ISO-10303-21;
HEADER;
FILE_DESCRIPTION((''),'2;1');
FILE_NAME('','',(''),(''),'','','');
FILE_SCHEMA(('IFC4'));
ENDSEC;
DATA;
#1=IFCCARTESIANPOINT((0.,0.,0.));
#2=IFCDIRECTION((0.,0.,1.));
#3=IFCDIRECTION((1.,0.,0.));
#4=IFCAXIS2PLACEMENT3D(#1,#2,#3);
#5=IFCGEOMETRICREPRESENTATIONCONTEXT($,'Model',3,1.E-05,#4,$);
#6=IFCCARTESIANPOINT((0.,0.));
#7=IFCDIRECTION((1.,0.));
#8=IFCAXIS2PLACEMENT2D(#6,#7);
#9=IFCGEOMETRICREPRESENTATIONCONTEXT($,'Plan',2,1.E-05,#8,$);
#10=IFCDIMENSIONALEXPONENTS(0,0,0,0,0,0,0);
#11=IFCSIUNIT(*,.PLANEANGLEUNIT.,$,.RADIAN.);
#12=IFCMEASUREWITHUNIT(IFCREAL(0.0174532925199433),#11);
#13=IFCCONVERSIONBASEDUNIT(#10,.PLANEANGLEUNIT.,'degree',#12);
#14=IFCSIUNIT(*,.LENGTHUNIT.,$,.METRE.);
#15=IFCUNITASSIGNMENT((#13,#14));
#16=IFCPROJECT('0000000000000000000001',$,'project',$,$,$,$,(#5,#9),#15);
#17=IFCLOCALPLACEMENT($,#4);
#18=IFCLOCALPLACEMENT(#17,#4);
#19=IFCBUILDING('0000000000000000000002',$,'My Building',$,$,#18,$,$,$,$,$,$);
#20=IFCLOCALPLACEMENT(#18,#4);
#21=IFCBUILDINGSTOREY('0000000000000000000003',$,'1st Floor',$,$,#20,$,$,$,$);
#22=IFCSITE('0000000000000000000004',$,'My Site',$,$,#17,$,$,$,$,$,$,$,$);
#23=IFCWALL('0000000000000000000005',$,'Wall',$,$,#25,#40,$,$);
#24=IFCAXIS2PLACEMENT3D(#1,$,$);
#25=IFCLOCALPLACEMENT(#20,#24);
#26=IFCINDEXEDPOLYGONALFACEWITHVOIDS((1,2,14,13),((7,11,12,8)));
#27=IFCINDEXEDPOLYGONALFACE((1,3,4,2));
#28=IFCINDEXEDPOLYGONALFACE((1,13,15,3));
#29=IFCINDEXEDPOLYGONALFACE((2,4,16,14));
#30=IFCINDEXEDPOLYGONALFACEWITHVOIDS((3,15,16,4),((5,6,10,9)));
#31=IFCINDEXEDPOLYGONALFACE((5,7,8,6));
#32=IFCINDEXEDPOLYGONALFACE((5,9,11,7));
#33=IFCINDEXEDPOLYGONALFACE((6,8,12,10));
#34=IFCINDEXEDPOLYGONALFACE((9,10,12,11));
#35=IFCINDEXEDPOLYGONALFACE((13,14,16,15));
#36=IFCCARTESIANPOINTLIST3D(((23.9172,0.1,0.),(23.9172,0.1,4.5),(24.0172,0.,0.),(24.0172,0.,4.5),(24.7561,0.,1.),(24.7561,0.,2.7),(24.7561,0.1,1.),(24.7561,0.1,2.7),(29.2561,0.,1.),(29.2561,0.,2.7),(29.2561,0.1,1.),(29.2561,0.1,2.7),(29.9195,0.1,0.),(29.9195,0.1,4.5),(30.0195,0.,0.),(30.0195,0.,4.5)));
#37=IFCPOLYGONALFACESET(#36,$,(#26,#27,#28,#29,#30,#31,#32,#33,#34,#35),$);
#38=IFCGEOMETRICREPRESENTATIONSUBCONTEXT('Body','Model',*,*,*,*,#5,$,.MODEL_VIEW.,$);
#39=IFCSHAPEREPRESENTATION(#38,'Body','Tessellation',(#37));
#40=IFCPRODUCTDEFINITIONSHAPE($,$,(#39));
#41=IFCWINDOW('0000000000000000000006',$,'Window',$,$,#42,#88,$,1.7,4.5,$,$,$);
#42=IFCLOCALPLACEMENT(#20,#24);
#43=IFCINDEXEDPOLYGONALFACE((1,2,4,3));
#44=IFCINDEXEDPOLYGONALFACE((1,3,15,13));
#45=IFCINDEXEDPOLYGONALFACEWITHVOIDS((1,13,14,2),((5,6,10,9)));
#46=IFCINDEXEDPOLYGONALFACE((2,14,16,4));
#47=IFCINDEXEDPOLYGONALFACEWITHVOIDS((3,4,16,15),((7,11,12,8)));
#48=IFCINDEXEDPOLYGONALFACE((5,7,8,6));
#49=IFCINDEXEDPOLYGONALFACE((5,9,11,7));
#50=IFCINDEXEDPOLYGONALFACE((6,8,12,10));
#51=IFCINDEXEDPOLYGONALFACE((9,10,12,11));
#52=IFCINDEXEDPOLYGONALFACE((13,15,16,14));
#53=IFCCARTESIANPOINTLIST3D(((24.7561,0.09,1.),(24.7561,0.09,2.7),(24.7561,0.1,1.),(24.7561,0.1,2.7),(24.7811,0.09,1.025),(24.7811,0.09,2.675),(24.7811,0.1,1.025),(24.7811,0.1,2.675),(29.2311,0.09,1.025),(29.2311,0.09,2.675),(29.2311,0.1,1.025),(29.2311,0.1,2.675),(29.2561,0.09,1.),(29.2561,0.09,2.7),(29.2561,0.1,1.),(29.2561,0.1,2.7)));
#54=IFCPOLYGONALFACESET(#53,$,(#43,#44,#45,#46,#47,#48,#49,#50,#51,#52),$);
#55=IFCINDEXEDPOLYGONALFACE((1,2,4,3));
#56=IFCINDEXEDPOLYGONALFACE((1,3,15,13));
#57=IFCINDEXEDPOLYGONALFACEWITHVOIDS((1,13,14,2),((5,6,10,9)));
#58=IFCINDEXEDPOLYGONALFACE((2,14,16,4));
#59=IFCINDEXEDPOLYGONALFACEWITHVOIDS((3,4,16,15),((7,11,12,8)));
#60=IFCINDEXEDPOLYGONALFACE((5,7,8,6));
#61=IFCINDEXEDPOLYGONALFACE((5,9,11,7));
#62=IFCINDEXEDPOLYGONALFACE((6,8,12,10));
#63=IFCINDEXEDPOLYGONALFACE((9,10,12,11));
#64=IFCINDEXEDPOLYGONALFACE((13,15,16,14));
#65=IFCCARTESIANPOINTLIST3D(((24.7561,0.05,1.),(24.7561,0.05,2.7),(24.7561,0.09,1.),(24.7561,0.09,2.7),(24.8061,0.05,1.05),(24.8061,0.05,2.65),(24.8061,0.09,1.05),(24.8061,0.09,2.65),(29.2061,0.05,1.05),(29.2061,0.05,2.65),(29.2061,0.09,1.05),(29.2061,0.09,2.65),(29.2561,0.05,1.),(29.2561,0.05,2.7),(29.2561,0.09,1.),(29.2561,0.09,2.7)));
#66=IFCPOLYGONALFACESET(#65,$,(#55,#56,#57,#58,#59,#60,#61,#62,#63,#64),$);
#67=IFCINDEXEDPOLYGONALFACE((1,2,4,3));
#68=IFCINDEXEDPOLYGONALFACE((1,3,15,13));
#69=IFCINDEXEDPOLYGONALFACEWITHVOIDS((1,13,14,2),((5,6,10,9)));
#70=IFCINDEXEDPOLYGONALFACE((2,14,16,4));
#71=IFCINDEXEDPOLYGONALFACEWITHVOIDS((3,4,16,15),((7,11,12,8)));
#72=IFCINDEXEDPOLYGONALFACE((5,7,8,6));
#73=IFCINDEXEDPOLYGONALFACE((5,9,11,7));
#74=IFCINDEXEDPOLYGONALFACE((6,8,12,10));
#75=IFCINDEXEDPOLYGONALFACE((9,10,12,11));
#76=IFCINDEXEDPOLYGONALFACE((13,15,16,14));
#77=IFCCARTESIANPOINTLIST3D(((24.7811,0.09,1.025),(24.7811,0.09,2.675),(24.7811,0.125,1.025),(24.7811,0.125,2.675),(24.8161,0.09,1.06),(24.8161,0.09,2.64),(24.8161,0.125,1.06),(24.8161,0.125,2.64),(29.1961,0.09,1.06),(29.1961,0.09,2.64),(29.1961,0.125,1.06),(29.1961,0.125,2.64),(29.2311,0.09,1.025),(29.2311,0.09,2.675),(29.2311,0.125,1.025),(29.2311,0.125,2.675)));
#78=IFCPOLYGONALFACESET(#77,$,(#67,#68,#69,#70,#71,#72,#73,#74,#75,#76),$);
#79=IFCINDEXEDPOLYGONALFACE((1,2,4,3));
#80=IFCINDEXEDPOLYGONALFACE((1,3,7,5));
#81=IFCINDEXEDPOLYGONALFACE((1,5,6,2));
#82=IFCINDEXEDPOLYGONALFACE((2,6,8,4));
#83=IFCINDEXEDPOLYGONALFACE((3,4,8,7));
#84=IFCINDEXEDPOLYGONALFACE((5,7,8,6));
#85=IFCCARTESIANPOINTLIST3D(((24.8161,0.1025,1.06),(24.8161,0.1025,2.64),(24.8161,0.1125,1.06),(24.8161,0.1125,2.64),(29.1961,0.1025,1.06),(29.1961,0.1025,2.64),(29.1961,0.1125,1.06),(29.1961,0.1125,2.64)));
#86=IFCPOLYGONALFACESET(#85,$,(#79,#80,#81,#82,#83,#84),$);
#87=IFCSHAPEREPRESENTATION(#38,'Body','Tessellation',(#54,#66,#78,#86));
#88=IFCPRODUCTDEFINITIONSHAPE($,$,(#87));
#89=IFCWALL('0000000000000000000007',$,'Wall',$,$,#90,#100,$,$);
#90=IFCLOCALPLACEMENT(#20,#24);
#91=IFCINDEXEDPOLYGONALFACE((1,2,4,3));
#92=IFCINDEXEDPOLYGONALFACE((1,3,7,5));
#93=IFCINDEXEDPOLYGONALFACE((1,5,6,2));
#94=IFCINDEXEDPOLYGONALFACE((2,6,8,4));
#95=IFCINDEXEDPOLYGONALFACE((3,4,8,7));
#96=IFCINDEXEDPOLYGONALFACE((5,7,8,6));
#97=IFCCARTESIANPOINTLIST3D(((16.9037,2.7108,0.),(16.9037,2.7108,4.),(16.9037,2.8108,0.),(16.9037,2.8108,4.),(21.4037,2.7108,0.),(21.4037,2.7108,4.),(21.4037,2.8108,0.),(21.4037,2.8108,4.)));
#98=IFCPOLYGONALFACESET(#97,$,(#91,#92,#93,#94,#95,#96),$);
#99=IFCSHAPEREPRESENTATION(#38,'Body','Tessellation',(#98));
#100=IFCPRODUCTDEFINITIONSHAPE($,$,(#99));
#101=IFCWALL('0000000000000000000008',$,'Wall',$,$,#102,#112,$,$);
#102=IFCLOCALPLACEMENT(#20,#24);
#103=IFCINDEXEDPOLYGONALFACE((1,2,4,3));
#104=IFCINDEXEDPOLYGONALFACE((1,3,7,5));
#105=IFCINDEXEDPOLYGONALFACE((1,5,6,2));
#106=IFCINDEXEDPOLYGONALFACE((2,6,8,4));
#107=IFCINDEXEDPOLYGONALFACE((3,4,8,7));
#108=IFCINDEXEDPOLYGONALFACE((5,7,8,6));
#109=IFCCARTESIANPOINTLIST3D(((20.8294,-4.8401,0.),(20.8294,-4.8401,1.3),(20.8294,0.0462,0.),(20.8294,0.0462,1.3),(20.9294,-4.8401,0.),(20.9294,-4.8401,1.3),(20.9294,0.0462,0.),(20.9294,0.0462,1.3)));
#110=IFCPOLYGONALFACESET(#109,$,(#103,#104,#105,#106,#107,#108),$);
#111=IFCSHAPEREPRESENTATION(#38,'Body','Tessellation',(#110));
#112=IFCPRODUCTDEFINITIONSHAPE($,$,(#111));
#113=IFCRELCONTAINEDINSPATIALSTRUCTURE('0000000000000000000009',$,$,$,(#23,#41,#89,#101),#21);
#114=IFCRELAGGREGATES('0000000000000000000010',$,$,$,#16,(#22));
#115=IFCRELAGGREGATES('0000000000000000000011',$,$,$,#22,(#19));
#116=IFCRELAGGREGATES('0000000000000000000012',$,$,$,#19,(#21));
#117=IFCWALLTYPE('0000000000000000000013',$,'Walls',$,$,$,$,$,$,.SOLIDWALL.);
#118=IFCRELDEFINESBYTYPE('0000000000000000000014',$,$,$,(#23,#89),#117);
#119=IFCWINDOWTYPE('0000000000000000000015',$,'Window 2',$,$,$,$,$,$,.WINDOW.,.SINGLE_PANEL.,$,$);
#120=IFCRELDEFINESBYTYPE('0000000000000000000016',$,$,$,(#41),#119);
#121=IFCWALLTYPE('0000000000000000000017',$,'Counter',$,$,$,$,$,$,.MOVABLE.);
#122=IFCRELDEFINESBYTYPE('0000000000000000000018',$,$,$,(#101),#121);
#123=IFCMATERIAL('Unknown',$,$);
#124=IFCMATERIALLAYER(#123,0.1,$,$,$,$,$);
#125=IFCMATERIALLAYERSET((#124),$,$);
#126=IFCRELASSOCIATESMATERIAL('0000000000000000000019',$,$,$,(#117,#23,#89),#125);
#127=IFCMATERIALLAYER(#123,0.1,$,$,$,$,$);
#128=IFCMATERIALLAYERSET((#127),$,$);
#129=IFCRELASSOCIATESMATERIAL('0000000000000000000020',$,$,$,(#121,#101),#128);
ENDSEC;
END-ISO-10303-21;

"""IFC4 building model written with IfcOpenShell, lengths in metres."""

from ifc_helpers import new_model, entity, si_unit, converted_unit, frame, origin_with_axes, origin_2d_with_axis, place, context, subcontext, project, spatial, line, indexed_curve, outline, extrude, shape, source, transform, mapped, material, layer, layer_set, layer_usage, type_object, type_shapes, element, fill, save


model = new_model("IFC4")

# Units and contexts
model_context = context("Model", 3, precision=1e-05, world=origin_with_axes())
plan_context = context("Plan", 2, precision=1e-05, world=origin_2d_with_axis())
body_context_1 = subcontext(model_context, "Body", "Model", "MODEL_VIEW")
body_context_2 = subcontext(plan_context, "Body", "Plan", "PLAN_VIEW")
ifc_project = project(units=[converted_unit("PLANEANGLEUNIT", "degree", entity("IfcReal", 0.0174532925199433), si_unit("PLANEANGLEUNIT", "RADIAN"), dimensions=[0, 0, 0, 0, 0, 0, 0]), si_unit("LENGTHUNIT", "METRE")], contexts=[model_context, plan_context])

# Site, building, storey
site_placement = place(None, origin_with_axes())
site = spatial("IfcSite", under=ifc_project, at=site_placement, Name="My Site")
building_placement = place(site_placement, origin_with_axes())
building = spatial("IfcBuilding", under=site, at=building_placement, Name="My Building")
storey_placement = place(building_placement, origin_with_axes())
storey = spatial("IfcBuildingStorey", under=building, at=storey_placement, Name="1st Floor")

# Shared definitions
ifc_material = material(Name="Unknown")

# Shared definitions
ifc_layer_1 = layer(ifc_material, 0.1)
ifc_layer_set_1 = layer_set([ifc_layer_1])
wall_type_1 = type_object("IfcWallType", Name="Walls", PredefinedType="SOLIDWALL", material=ifc_layer_set_1)

# Wall, opening, window
ifc_layer_usage_1 = layer_usage(ifc_layer_set_1, "AXIS2", "POSITIVE", 0.0)
wall_1_placement = place(storey_placement, frame((24.0172, 0.0, 0.0), z_axis=(0.0, 0.0, 1.0), x_axis=(1.0, 0.0, 0.0)))
wall_1 = element("IfcWall", 1, at=wall_1_placement, inside=storey, type_object=wall_type_1, material=ifc_layer_usage_1, Name="Wall", context=body_context_1, shape_type="SweptSolid", body=[
    extrude(outline(indexed_curve([(0.0, 0.0), (-0.1, 0.1), (5.9023, 0.1), (6.0023, 0.0)], segments=[line(1, 2, 3, 4, 1)])), origin_with_axes(), (0.0, 0.0, 1.0), 4.5),
])
shared_shape_1 = source(origin_with_axes(), body_context_1, "Body", "SweptSolid", [
    extrude(outline(indexed_curve([(0.0, 0.0), (4.5, 0.0), (4.5, 1.7), (0.0, 1.7)], segments=[line(1, 2, 3, 4, 1)])), frame((0.0, -0.6, 0.0), z_axis=(0.0, -1.0, 0.0), x_axis=(1.0, 0.0, 0.0)), (0.0, 0.0, -1.0), 1.2),
])
opening_1_placement = place(wall_1_placement, frame((0.7389, 0.0, 1.0), z_axis=(0.0, 0.0, 1.0), x_axis=(1.0, 0.0, 0.0)))
opening_1 = element("IfcOpeningElement", 2, at=opening_1_placement, cuts=wall_1, PredefinedType="OPENING", context=body_context_1, shape_type="MappedRepresentation", body=[
    mapped(shared_shape_1, transform((0.0, 0.0, 0.0), x_axis=(1.0, 0.0, 0.0), y_axis=(0.0, 1.0, 0.0), z_axis=(0.0, 0.0, 1.0), scale=1.0)),
])
window_type_1 = type_object("IfcWindowType", Name="Window 2", PartitioningType="SINGLE_PANEL", PredefinedType="WINDOW")
shared_shape_2 = source(origin_with_axes(), body_context_1, "Body", "SweptSolid", [
    extrude(outline(indexed_curve([(0.0, 0.0), (4.5, 0.0), (4.5, 1.7), (0.0, 1.7)], segments=[line(1, 2, 3, 4, 1)]), holes=[indexed_curve([(0.025, 0.025), (4.475, 0.025), (4.475, 1.675), (0.025, 1.675)], segments=[line(1, 2, 3, 4, 1)])]), frame((0.0, 0.09, 0.0), z_axis=(0.0, -1.0, 0.0), x_axis=(1.0, 0.0, 0.0)), (0.0, 0.0, -1.0), 0.01),
    extrude(outline(indexed_curve([(0.0, 0.0), (4.5, 0.0), (4.5, 1.7), (0.0, 1.7)], segments=[line(1, 2, 3, 4, 1)]), holes=[indexed_curve([(0.05, 0.05), (4.45, 0.05), (4.45, 1.65), (0.05, 1.65)], segments=[line(1, 2, 3, 4, 1)])]), frame((0.0, 0.05, 0.0), z_axis=(0.0, -1.0, 0.0), x_axis=(1.0, 0.0, 0.0)), (0.0, 0.0, -1.0), 0.04),
    extrude(outline(indexed_curve([(0.0, 0.0), (4.45, 0.0), (4.45, 1.65), (0.0, 1.65)], segments=[line(1, 2, 3, 4, 1)]), holes=[indexed_curve([(0.035, 0.035), (4.415, 0.035), (4.415, 1.615), (0.035, 1.615)], segments=[line(1, 2, 3, 4, 1)])]), frame((0.025, 0.09, 0.025), z_axis=(0.0, -1.0, 0.0), x_axis=(1.0, 0.0, 0.0)), (0.0, 0.0, -1.0), 0.035),
    extrude(outline(indexed_curve([(0.035, 0.035), (4.415, 0.035), (4.415, 1.615), (0.035, 1.615)], segments=[line(1, 2, 3, 4, 1)])), frame((0.025, 0.1025, 0.025), z_axis=(0.0, -1.0, 0.0), x_axis=(1.0, 0.0, 0.0)), (0.0, 0.0, -1.0), 0.01),
])
shared_shape_3 = source(origin_with_axes(), body_context_2, "Body", "Curve2D", [
    entity("IfcIndexedPolyCurve", entity("IfcCartesianPointList2D", [[0.05, 0.05], [4.45, 0.05]])),
    entity("IfcIndexedPolyCurve", entity("IfcCartesianPointList2D", [[0.0, 0.1], [0.025, 0.1], [0.025, 0.09], [0.05, 0.09], [0.05, 0.05], [0.0, 0.05]]), [entity("IfcLineIndex", [1, 2, 3, 4, 5, 6, 1])]),
    entity("IfcIndexedPolyCurve", entity("IfcCartesianPointList2D", [[4.5, 0.1], [4.475, 0.1], [4.475, 0.09], [4.45, 0.09], [4.45, 0.05], [4.5, 0.05]]), [entity("IfcLineIndex", [1, 2, 3, 4, 5, 6, 1])]),
    entity("IfcIndexedPolyCurve", entity("IfcCartesianPointList2D", [[0.025, 0.09], [0.06, 0.09], [0.06, 0.125], [0.025, 0.125]]), [entity("IfcLineIndex", [1, 2, 3, 4, 1])]),
    entity("IfcIndexedPolyCurve", entity("IfcCartesianPointList2D", [[4.475, 0.09], [4.44, 0.09], [4.44, 0.125], [4.475, 0.125]]), [entity("IfcLineIndex", [1, 2, 3, 4, 1])]),
    entity("IfcIndexedPolyCurve", entity("IfcCartesianPointList2D", [[0.06, 0.09], [4.44, 0.09]])),
    entity("IfcIndexedPolyCurve", entity("IfcCartesianPointList2D", [[0.06, 0.125], [4.44, 0.125]])),
    entity("IfcIndexedPolyCurve", entity("IfcCartesianPointList2D", [[0.06, 0.1075], [4.44, 0.1075]])),
])
type_shapes(window_type_1, [shared_shape_2, shared_shape_3])
window_1_placement = place(opening_1_placement, origin_with_axes())
window_1 = element("IfcWindow", 3, at=window_1_placement, inside=storey, type_object=window_type_1, Name="Window", OverallHeight=1.7, OverallWidth=4.5, shapes=[
    shape(body_context_1, "Body", "MappedRepresentation", [mapped(shared_shape_2, transform((0.0, 0.0, 0.0), x_axis=(1.0, 0.0, 0.0), y_axis=(0.0, 1.0, 0.0), z_axis=(0.0, 0.0, 1.0), scale=1.0))]),
    shape(body_context_2, "Body", "MappedRepresentation", [mapped(shared_shape_3, transform((0.0, 0.0, 0.0), x_axis=(1.0, 0.0, 0.0), y_axis=(0.0, 1.0, 0.0), z_axis=(0.0, 0.0, 1.0), scale=1.0))]),
])
fill(opening_1, window_1)

# Walls
ifc_layer_usage_2 = layer_usage(ifc_layer_set_1, "AXIS2", "POSITIVE", 0.0)
wall_2_placement = place(storey_placement, frame((16.9037, 2.7108, 0.0), z_axis=(0.0, 0.0, 1.0), x_axis=(1.0, 0.0, 0.0)))
element("IfcWall", 4, at=wall_2_placement, inside=storey, type_object=wall_type_1, material=ifc_layer_usage_2, Name="Wall", context=body_context_1, shape_type="SweptSolid", body=[
    extrude(outline(indexed_curve([(0.0, 0.0), (0.0, 0.1), (4.5, 0.1), (4.5, 0.0)], segments=[line(1, 2, 3, 4, 1)])), origin_with_axes(), (0.0, 0.0, 1.0), 4.0),
])
ifc_layer_2 = layer(ifc_material, 0.1)
ifc_layer_set_2 = layer_set([ifc_layer_2])
ifc_layer_usage_3 = layer_usage(ifc_layer_set_2, "AXIS2", "POSITIVE", 0.0)
wall_type_2 = type_object("IfcWallType", Name="Counter", PredefinedType="MOVABLE", material=ifc_layer_set_2)
wall_3_placement = place(storey_placement, frame((20.8294, 0.0462, 0.0), z_axis=(0.0, 0.0, 1.0), x_axis=(0.000001, -1.0, 0.0)))
element("IfcWall", 5, at=wall_3_placement, inside=storey, type_object=wall_type_2, material=ifc_layer_usage_3, Name="Wall", context=body_context_1, shape_type="SweptSolid", body=[
    extrude(outline(indexed_curve([(0.0, 0.0), (0.0, 0.1), (4.8863, 0.1), (4.8863, 0.0)], segments=[line(1, 2, 3, 4, 1)])), origin_with_axes(), (0.0, 0.0, 1.0), 1.3),
])

save(model, "model.ifc")
